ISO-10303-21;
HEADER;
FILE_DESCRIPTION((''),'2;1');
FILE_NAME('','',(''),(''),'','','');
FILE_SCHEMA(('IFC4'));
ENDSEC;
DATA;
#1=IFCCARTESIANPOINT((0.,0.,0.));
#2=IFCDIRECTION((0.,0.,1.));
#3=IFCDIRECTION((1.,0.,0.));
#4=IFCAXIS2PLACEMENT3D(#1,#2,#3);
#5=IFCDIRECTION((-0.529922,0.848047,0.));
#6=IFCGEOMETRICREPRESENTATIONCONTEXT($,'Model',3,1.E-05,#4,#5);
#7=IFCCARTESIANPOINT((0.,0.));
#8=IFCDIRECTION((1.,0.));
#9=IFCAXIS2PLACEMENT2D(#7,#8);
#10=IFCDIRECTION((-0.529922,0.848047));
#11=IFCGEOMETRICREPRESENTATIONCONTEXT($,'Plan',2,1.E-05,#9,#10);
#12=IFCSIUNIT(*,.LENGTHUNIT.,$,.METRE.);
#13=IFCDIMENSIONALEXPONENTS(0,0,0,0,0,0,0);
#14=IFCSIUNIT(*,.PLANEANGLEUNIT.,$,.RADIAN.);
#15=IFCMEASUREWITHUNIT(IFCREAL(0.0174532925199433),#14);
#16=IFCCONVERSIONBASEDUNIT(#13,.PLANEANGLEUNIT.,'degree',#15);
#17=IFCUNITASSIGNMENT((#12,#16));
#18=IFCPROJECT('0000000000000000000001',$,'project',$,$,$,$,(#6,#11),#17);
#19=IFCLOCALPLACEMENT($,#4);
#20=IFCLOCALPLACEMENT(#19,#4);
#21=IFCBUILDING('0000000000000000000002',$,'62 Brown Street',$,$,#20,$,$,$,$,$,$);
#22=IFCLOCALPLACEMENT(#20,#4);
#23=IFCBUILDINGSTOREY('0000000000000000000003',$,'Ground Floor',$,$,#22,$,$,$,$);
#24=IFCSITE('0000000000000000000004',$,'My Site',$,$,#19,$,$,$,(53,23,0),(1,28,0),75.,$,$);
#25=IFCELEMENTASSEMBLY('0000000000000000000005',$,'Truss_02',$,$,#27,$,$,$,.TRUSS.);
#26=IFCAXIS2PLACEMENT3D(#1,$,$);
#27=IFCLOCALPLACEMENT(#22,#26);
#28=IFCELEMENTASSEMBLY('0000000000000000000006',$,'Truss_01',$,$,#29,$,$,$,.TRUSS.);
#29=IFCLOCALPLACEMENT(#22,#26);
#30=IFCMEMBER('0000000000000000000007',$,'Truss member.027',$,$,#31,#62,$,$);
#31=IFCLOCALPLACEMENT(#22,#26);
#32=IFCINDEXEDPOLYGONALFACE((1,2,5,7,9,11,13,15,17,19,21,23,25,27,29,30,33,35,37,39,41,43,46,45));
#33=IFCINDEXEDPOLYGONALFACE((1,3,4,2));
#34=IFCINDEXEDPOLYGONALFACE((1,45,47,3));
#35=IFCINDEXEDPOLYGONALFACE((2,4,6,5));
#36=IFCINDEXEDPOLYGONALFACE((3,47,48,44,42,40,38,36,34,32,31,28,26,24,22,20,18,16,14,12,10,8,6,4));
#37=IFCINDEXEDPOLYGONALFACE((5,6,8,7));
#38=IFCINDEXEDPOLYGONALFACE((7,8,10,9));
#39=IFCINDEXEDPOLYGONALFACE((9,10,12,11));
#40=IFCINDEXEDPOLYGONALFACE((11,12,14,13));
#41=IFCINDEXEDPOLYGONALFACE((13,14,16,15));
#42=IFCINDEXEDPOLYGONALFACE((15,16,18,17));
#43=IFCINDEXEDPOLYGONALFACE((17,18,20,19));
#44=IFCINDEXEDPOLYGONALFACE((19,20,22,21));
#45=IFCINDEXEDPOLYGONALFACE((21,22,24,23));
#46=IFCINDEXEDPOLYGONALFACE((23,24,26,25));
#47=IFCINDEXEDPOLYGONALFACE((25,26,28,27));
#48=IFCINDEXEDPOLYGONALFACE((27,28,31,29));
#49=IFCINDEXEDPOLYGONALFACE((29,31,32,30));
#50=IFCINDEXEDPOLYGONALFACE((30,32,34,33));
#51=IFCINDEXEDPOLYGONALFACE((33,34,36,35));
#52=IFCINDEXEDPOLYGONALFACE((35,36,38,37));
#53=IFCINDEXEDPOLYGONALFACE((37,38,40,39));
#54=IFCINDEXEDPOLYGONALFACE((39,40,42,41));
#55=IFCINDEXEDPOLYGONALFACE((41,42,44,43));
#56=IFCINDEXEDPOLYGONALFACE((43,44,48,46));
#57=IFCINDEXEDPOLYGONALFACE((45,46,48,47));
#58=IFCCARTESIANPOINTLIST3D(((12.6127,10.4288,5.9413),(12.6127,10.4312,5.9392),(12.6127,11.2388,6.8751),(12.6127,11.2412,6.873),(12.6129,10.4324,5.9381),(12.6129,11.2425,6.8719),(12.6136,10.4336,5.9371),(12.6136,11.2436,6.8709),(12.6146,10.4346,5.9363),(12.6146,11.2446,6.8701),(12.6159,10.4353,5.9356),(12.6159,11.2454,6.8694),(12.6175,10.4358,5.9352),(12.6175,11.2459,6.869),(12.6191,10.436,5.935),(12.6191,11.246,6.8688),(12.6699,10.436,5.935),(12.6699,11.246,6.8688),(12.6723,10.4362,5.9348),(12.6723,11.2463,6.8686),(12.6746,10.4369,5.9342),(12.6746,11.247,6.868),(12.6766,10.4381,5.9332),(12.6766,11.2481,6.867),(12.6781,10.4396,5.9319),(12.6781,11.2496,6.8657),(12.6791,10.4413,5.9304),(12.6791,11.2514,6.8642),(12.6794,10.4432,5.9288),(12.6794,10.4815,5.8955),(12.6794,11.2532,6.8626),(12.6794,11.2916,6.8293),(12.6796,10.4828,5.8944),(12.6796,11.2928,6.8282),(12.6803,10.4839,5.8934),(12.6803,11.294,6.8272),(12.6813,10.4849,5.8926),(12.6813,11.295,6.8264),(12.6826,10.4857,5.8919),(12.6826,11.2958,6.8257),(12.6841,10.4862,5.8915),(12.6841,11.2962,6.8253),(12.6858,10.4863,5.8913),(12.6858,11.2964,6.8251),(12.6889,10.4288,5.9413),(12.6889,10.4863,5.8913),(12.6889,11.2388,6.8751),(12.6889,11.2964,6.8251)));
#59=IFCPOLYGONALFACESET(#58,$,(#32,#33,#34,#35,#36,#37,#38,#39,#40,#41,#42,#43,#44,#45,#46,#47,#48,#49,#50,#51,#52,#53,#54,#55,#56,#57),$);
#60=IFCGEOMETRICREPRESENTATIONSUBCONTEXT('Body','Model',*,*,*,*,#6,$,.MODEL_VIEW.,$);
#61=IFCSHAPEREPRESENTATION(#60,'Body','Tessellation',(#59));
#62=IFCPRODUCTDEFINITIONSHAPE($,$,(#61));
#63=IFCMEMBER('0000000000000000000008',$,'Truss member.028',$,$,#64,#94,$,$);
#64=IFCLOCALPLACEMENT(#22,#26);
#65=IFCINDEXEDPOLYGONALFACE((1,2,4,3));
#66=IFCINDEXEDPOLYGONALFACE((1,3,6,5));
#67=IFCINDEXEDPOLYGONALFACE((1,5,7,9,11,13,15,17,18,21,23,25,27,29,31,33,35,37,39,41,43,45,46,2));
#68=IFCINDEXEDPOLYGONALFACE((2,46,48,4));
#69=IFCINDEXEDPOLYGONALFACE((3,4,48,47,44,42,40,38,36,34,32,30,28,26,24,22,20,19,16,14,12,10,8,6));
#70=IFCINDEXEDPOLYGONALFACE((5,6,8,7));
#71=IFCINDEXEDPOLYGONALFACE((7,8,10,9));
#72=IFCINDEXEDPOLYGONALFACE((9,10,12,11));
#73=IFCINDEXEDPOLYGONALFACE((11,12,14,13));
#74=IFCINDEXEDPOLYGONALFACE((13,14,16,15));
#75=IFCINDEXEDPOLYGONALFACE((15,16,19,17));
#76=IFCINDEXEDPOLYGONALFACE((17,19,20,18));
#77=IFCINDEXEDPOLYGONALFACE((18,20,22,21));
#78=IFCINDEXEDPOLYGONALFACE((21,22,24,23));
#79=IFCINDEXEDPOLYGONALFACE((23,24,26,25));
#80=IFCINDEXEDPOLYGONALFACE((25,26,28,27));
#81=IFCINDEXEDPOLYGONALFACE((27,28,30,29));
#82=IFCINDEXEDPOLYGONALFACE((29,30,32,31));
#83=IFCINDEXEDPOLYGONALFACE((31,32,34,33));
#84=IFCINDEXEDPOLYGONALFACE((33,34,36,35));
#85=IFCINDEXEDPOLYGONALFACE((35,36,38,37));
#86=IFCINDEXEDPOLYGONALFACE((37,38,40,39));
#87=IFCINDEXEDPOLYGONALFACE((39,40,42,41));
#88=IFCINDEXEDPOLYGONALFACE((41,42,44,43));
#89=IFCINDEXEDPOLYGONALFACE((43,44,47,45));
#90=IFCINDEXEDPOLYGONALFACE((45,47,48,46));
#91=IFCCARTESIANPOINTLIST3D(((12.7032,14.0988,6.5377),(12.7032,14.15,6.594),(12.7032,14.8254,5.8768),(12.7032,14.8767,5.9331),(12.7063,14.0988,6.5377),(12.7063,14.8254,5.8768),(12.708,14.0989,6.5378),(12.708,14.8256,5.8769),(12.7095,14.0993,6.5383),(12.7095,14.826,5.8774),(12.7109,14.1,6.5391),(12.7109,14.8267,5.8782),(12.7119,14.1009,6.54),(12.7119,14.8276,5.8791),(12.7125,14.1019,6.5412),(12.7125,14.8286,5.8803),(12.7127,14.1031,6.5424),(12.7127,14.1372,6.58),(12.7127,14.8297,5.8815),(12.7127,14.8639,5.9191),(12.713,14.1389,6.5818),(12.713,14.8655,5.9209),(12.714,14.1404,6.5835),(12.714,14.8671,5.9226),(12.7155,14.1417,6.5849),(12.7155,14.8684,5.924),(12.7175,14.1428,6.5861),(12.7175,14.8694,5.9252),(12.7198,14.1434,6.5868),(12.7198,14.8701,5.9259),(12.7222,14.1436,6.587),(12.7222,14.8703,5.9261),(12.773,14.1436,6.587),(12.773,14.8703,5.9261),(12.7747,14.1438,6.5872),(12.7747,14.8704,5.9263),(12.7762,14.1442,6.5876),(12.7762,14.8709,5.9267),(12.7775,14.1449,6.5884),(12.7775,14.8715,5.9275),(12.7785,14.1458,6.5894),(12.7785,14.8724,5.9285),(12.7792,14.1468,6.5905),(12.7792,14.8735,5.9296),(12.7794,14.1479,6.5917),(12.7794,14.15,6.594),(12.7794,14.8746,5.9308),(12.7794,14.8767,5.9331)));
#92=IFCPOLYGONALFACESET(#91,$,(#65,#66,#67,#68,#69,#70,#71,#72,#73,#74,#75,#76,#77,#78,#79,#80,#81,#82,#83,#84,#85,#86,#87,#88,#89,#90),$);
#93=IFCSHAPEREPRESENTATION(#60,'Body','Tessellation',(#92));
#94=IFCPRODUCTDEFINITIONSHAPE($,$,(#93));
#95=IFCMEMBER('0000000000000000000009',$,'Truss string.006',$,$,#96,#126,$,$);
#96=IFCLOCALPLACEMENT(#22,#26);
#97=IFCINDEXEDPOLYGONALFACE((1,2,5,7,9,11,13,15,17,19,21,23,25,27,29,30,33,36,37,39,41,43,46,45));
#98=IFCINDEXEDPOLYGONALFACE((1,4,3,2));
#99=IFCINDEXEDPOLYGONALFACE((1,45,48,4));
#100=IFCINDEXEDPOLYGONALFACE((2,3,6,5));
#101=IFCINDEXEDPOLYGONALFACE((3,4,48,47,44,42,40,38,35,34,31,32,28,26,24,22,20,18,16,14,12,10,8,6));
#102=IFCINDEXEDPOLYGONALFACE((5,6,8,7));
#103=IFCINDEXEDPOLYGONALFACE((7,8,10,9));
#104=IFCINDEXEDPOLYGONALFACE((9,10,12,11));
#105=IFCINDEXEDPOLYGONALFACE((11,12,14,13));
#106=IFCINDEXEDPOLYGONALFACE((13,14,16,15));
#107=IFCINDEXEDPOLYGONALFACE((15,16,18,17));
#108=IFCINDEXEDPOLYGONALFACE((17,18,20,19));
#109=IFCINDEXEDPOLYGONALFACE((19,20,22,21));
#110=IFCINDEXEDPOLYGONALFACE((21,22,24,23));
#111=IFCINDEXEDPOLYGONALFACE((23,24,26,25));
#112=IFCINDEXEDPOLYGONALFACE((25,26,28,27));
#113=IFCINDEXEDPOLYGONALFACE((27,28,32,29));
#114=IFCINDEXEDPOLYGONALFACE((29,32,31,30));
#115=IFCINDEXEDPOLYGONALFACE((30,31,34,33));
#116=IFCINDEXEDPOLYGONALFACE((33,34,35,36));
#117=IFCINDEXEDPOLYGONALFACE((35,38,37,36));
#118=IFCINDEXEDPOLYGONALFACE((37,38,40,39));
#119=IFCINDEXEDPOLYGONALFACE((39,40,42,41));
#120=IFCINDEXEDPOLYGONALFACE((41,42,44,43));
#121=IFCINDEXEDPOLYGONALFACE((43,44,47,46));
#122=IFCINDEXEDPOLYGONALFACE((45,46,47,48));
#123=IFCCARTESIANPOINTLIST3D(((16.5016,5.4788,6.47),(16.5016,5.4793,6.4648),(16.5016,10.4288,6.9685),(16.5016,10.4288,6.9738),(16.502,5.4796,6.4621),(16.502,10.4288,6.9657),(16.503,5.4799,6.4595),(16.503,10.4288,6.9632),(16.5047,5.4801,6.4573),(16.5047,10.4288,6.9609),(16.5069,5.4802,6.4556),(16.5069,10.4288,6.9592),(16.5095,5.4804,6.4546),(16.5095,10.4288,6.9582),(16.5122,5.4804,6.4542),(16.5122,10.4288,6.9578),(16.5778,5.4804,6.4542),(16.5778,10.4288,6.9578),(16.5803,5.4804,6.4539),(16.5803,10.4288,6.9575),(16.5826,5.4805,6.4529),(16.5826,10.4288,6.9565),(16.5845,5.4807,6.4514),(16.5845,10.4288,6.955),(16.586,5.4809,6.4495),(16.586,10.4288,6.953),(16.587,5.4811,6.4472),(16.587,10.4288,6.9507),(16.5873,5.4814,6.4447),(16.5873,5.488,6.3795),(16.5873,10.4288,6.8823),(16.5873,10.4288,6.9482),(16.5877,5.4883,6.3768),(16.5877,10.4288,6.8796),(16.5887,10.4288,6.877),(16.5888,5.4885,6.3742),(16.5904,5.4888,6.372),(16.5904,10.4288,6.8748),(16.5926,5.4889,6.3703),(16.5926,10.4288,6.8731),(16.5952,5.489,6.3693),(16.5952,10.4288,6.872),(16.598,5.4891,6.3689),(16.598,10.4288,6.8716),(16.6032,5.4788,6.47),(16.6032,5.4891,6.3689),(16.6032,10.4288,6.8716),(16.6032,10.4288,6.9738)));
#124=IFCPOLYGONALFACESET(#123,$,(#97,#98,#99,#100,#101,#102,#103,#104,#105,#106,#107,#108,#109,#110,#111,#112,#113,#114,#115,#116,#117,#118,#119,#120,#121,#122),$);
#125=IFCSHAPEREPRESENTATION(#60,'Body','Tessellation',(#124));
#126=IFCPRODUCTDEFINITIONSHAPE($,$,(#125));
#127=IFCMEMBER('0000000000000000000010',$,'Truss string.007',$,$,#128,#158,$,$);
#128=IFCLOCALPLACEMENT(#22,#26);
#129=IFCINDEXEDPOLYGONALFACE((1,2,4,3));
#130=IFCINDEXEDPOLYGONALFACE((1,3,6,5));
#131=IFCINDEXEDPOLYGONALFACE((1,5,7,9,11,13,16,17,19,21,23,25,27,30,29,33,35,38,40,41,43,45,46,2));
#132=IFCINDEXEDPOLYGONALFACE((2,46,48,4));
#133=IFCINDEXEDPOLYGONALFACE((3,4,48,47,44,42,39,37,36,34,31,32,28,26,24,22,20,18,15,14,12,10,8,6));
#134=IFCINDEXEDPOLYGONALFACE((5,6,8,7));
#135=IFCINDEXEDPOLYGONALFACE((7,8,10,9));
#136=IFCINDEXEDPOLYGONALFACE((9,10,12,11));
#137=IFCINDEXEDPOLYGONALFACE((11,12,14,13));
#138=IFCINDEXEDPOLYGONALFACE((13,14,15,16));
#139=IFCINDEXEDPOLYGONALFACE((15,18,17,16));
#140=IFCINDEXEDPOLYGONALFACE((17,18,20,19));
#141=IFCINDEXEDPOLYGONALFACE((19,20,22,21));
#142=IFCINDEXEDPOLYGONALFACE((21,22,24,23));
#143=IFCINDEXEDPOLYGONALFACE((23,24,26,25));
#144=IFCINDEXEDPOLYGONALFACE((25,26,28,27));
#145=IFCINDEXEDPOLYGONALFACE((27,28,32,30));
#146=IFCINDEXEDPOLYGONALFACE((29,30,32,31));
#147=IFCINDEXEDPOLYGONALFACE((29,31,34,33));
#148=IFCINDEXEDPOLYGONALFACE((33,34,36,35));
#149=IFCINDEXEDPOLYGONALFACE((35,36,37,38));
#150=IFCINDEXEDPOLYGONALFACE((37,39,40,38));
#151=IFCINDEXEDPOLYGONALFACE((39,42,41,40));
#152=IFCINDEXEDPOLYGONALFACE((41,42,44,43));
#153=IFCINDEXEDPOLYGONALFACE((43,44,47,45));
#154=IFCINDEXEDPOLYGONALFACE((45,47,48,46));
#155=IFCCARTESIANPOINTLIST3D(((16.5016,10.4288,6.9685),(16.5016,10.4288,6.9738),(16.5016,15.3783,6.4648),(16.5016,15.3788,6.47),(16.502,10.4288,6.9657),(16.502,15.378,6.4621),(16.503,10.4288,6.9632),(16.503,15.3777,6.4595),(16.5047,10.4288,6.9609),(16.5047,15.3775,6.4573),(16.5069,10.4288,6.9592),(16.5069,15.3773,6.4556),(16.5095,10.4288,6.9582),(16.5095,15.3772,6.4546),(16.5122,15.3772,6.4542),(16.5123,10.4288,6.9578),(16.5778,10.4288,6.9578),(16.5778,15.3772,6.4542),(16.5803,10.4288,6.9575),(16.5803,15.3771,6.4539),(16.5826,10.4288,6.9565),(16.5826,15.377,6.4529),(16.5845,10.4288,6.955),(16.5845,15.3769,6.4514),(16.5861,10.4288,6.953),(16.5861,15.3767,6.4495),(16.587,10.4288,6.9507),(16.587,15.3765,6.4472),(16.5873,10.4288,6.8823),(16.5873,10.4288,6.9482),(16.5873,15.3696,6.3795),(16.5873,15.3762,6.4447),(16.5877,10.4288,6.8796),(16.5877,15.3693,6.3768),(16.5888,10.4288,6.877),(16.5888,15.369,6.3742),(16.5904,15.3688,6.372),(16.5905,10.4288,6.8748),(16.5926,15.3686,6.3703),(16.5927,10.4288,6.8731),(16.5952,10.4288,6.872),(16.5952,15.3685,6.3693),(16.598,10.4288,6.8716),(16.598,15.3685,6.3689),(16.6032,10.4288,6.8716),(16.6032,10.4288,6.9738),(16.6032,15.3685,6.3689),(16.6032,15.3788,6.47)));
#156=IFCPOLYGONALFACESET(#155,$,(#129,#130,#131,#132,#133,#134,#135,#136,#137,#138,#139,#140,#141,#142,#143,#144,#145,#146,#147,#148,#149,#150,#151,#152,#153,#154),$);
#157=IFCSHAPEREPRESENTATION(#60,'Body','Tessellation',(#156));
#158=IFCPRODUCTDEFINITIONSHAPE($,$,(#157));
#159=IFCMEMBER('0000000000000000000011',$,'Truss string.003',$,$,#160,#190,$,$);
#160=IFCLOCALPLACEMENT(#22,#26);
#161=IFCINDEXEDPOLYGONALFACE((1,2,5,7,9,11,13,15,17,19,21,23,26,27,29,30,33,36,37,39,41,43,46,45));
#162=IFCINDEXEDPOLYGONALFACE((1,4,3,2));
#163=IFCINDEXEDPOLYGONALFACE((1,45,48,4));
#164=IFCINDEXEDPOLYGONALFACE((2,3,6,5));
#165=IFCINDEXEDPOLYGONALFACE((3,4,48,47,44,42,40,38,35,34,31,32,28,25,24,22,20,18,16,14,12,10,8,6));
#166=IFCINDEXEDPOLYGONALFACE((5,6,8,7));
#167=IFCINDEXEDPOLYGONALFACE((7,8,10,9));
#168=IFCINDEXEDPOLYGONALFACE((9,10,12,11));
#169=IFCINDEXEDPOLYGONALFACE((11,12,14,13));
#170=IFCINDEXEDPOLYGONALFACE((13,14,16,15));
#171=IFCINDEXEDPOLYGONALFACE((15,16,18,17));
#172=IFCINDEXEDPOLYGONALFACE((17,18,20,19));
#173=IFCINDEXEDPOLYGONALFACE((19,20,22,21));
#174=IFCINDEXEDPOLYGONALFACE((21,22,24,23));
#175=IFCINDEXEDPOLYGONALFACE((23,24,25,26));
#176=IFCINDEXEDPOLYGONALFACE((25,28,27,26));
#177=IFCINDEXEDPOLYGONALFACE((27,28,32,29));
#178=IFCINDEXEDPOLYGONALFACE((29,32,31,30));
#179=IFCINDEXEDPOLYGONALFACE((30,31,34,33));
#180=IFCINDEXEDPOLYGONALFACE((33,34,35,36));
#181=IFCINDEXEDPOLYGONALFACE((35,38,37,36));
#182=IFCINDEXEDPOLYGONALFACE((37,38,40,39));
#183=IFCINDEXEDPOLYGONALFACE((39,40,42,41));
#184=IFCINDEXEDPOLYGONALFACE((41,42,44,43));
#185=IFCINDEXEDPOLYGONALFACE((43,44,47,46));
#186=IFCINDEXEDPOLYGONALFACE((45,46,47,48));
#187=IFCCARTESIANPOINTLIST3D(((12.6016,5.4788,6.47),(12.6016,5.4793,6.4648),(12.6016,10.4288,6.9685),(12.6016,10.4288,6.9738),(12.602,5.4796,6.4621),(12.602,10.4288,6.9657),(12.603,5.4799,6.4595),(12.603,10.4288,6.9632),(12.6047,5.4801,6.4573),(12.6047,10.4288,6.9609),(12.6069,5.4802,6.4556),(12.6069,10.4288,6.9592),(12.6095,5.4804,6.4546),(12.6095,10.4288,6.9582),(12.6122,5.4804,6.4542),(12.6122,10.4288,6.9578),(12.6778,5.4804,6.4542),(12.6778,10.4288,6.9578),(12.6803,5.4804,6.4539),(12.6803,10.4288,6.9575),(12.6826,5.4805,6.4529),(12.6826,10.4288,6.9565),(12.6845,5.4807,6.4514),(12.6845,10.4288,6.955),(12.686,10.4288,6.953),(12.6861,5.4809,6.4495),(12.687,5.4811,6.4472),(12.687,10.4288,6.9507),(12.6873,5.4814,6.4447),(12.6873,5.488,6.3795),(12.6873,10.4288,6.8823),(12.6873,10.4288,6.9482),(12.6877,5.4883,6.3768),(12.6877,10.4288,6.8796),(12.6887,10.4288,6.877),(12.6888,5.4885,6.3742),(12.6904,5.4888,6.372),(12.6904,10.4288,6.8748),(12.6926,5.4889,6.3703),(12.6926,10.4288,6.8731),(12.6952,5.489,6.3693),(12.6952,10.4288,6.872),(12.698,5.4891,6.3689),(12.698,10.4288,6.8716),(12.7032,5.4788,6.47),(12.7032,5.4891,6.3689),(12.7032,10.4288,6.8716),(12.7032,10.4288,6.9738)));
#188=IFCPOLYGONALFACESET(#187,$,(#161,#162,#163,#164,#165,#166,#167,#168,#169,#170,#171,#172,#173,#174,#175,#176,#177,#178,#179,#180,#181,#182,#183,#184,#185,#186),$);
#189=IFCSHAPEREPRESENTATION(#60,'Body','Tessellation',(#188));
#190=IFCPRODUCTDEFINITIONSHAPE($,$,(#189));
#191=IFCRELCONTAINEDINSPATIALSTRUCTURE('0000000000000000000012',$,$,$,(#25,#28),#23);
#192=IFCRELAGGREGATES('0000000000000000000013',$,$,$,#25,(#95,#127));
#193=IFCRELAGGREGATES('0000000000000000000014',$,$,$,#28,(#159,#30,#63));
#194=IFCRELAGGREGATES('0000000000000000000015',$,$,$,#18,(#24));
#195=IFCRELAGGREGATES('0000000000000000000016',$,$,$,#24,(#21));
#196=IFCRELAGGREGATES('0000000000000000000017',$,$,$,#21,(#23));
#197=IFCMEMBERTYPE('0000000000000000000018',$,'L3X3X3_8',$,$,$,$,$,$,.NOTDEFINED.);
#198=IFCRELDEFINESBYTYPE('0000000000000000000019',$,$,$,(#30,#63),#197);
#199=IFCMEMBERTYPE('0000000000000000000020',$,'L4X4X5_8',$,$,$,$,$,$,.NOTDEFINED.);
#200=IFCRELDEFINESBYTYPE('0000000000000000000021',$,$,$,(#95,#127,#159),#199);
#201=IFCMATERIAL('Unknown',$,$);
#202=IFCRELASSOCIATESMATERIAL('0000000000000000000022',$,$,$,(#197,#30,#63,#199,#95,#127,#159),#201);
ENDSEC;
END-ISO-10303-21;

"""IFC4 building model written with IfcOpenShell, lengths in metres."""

from ifc_helpers import new_model, entity, si_unit, converted_unit, direction, frame, origin_with_axes, origin_2d_with_axis, place, context, subcontext, project, spatial, l_section, extrude, clip, halfspace, material, material_profile, profile_set, profile_usage, type_object, element, aggregate, save


model = new_model("IFC4")

# Units and contexts
model_context = context("Model", 3, precision=1e-05, world=origin_with_axes(), true_north=direction((-0.529922, 0.848047, 0.0)))
plan_context = context("Plan", 2, precision=1e-05, world=origin_2d_with_axis(), true_north=direction((-0.529922, 0.848047)))
body_context = subcontext(model_context, "Body", "Model", "MODEL_VIEW")
ifc_project = project(units=[si_unit("LENGTHUNIT", "METRE"), converted_unit("PLANEANGLEUNIT", "degree", entity("IfcReal", 0.0174532925199433), si_unit("PLANEANGLEUNIT", "RADIAN"), dimensions=[0, 0, 0, 0, 0, 0, 0])], contexts=[model_context, plan_context])

# Site, building, storey
site_placement = place(None, origin_with_axes())
site = spatial("IfcSite", under=ifc_project, at=site_placement, Name="My Site", RefLatitude=(53, 23, 0), RefLongitude=(1, 28, 0), RefElevation=75.0)
building_placement = place(site_placement, origin_with_axes())
building = spatial("IfcBuilding", under=site, at=building_placement, Name="62 Brown Street")
storey_placement = place(building_placement, origin_with_axes())
storey = spatial("IfcBuildingStorey", under=building, at=storey_placement, Name="Ground Floor")

# Element assemblies, members
ifc_material_1 = material(Name="Unknown")
ifc_material_profile_1 = material_profile(ifc_material_1, l_section(Depth=0.0762, Width=0.0762, Thickness=0.0095, FilletRadius=0.0095, EdgeRadius=0.0064))
ifc_profile_set_1 = profile_set([ifc_material_profile_1])
member_type_1 = type_object("IfcMemberType", Name="L3X3X3_8", PredefinedType="NOTDEFINED", material=ifc_profile_set_1)
assembly_1_placement = place(storey_placement, frame((16.6032, 10.4288, 6.9738), z_axis=(0.0, 0.0, 1.0), x_axis=(1.0, 0.0, 0.0)))
assembly_1 = element("IfcElementAssembly", 1, at=assembly_1_placement, inside=storey, Name="Truss_02", PredefinedType="TRUSS")
assembly_2_placement = place(storey_placement, frame((12.7032, 10.4288, 6.9738), z_axis=(0.0, 0.0, 1.0), x_axis=(1.0, 0.0, 0.0)))
assembly_2 = element("IfcElementAssembly", 2, at=assembly_2_placement, inside=storey, Name="Truss_01", PredefinedType="TRUSS")
ifc_profile_usage_1 = profile_usage(ifc_profile_set_1, cardinal=5)
member_1_placement = place(assembly_2_placement, frame((-0.0524, 0.8388, -0.1236), z_axis=(0.000001, -0.655276, -0.755389), x_axis=(-1.0, -0.000001, 0.0)))
member_1 = element("IfcMember", 3, at=member_1_placement, type_object=member_type_1, material=ifc_profile_usage_1, Name="Truss member.027", context=body_context, shape_type="SweptSolid", body=[
    extrude(l_section(Depth=0.0762, Width=0.0762, Thickness=0.0095, FilletRadius=0.0095, EdgeRadius=0.0064), origin_with_axes(), (0.0, 0.0, 1.0), 1.2362),
])
ifc_profile_usage_2 = profile_usage(ifc_profile_set_1, cardinal=5)
member_2_placement = place(assembly_2_placement, frame((0.0381, 3.6956, -0.4079), z_axis=(-0.000001, 0.739785, -0.672843), x_axis=(1.0, 0.000001, 0.0)))
member_2 = element("IfcMember", 4, at=member_2_placement, type_object=member_type_1, material=ifc_profile_usage_2, Name="Truss member.028", context=body_context, shape_type="SweptSolid", body=[
    extrude(l_section(Depth=0.0762, Width=0.0762, Thickness=0.0095, FilletRadius=0.0095, EdgeRadius=0.0064), origin_with_axes(), (0.0, 0.0, 1.0), 0.9823),
])

# Members
ifc_material_profile_2 = material_profile(ifc_material_1, l_section(Depth=0.1016, Width=0.1016, Thickness=0.0159, FilletRadius=0.0095, EdgeRadius=0.0106))
ifc_profile_set_2 = profile_set([ifc_material_profile_2])
ifc_profile_usage_3 = profile_usage(ifc_profile_set_2, cardinal=5)
member_type_2 = type_object("IfcMemberType", Name="L4X4X5_8", PredefinedType="NOTDEFINED", material=ifc_profile_set_2)
member_3_placement = place(assembly_1_placement, frame((-0.0508, 0.3519, -0.0152), z_axis=(0.000001, -0.994861, -0.101247), x_axis=(-1.0, -0.000001, 0.0)))
member_3 = element("IfcMember", 5, at=member_3_placement, type_object=member_type_2, material=ifc_profile_usage_3, Name="Truss string.006", context=body_context, shape_type="Clipping", body=[
    clip(extrude(l_section(Depth=0.1016, Width=0.1016, Thickness=0.0159, FilletRadius=0.0095, EdgeRadius=0.0106), origin_with_axes(), (0.0, 0.0, 1.0), 5.3242), halfspace(frame((16.4524, -0.0508, 0.3486), z_axis=(0.0, 0.101247, -0.994861), x_axis=(1.0, -0.000001, 0.0)), False)),
])
ifc_profile_usage_4 = profile_usage(ifc_profile_set_2, cardinal=5)
member_4_placement = place(assembly_1_placement, frame((-0.0508, 4.9449, -0.5543), z_axis=(0.000001, -0.994861, 0.101247), x_axis=(-1.0, -0.000001, 0.0)))
member_4 = element("IfcMember", 6, at=member_4_placement, type_object=member_type_2, material=ifc_profile_usage_4, Name="Truss string.007", context=body_context, shape_type="Clipping", body=[
    clip(extrude(l_section(Depth=0.1016, Width=0.1016, Thickness=0.0159, FilletRadius=0.0095, EdgeRadius=0.0106), origin_with_axes(), (0.0, 0.0, 1.0), 5.3242), halfspace(frame((16.4524, -0.0508, 4.9756), z_axis=(0.0, 0.101247, 0.994861), x_axis=(1.0, -0.000001, 0.0)), False)),
])
aggregate(assembly_1, [member_3, member_4])
ifc_profile_usage_5 = profile_usage(ifc_profile_set_2, cardinal=5)
member_5_placement = place(assembly_2_placement, frame((-0.0508, 0.3519, -0.0152), z_axis=(0.000001, -0.994861, -0.101247), x_axis=(-1.0, -0.000001, 0.0)))
member_5 = element("IfcMember", 7, at=member_5_placement, type_object=member_type_2, material=ifc_profile_usage_5, Name="Truss string.003", context=body_context, shape_type="Clipping", body=[
    clip(extrude(l_section(Depth=0.1016, Width=0.1016, Thickness=0.0159, FilletRadius=0.0095, EdgeRadius=0.0106), origin_with_axes(), (0.0, 0.0, 1.0), 5.3242), halfspace(frame((16.4524, -0.0508, 0.3486), z_axis=(0.0, 0.101247, -0.994861), x_axis=(1.0, -0.000001, 0.0)), False)),
])
aggregate(assembly_2, [member_5, member_1, member_2])

save(model, "model.ifc")
